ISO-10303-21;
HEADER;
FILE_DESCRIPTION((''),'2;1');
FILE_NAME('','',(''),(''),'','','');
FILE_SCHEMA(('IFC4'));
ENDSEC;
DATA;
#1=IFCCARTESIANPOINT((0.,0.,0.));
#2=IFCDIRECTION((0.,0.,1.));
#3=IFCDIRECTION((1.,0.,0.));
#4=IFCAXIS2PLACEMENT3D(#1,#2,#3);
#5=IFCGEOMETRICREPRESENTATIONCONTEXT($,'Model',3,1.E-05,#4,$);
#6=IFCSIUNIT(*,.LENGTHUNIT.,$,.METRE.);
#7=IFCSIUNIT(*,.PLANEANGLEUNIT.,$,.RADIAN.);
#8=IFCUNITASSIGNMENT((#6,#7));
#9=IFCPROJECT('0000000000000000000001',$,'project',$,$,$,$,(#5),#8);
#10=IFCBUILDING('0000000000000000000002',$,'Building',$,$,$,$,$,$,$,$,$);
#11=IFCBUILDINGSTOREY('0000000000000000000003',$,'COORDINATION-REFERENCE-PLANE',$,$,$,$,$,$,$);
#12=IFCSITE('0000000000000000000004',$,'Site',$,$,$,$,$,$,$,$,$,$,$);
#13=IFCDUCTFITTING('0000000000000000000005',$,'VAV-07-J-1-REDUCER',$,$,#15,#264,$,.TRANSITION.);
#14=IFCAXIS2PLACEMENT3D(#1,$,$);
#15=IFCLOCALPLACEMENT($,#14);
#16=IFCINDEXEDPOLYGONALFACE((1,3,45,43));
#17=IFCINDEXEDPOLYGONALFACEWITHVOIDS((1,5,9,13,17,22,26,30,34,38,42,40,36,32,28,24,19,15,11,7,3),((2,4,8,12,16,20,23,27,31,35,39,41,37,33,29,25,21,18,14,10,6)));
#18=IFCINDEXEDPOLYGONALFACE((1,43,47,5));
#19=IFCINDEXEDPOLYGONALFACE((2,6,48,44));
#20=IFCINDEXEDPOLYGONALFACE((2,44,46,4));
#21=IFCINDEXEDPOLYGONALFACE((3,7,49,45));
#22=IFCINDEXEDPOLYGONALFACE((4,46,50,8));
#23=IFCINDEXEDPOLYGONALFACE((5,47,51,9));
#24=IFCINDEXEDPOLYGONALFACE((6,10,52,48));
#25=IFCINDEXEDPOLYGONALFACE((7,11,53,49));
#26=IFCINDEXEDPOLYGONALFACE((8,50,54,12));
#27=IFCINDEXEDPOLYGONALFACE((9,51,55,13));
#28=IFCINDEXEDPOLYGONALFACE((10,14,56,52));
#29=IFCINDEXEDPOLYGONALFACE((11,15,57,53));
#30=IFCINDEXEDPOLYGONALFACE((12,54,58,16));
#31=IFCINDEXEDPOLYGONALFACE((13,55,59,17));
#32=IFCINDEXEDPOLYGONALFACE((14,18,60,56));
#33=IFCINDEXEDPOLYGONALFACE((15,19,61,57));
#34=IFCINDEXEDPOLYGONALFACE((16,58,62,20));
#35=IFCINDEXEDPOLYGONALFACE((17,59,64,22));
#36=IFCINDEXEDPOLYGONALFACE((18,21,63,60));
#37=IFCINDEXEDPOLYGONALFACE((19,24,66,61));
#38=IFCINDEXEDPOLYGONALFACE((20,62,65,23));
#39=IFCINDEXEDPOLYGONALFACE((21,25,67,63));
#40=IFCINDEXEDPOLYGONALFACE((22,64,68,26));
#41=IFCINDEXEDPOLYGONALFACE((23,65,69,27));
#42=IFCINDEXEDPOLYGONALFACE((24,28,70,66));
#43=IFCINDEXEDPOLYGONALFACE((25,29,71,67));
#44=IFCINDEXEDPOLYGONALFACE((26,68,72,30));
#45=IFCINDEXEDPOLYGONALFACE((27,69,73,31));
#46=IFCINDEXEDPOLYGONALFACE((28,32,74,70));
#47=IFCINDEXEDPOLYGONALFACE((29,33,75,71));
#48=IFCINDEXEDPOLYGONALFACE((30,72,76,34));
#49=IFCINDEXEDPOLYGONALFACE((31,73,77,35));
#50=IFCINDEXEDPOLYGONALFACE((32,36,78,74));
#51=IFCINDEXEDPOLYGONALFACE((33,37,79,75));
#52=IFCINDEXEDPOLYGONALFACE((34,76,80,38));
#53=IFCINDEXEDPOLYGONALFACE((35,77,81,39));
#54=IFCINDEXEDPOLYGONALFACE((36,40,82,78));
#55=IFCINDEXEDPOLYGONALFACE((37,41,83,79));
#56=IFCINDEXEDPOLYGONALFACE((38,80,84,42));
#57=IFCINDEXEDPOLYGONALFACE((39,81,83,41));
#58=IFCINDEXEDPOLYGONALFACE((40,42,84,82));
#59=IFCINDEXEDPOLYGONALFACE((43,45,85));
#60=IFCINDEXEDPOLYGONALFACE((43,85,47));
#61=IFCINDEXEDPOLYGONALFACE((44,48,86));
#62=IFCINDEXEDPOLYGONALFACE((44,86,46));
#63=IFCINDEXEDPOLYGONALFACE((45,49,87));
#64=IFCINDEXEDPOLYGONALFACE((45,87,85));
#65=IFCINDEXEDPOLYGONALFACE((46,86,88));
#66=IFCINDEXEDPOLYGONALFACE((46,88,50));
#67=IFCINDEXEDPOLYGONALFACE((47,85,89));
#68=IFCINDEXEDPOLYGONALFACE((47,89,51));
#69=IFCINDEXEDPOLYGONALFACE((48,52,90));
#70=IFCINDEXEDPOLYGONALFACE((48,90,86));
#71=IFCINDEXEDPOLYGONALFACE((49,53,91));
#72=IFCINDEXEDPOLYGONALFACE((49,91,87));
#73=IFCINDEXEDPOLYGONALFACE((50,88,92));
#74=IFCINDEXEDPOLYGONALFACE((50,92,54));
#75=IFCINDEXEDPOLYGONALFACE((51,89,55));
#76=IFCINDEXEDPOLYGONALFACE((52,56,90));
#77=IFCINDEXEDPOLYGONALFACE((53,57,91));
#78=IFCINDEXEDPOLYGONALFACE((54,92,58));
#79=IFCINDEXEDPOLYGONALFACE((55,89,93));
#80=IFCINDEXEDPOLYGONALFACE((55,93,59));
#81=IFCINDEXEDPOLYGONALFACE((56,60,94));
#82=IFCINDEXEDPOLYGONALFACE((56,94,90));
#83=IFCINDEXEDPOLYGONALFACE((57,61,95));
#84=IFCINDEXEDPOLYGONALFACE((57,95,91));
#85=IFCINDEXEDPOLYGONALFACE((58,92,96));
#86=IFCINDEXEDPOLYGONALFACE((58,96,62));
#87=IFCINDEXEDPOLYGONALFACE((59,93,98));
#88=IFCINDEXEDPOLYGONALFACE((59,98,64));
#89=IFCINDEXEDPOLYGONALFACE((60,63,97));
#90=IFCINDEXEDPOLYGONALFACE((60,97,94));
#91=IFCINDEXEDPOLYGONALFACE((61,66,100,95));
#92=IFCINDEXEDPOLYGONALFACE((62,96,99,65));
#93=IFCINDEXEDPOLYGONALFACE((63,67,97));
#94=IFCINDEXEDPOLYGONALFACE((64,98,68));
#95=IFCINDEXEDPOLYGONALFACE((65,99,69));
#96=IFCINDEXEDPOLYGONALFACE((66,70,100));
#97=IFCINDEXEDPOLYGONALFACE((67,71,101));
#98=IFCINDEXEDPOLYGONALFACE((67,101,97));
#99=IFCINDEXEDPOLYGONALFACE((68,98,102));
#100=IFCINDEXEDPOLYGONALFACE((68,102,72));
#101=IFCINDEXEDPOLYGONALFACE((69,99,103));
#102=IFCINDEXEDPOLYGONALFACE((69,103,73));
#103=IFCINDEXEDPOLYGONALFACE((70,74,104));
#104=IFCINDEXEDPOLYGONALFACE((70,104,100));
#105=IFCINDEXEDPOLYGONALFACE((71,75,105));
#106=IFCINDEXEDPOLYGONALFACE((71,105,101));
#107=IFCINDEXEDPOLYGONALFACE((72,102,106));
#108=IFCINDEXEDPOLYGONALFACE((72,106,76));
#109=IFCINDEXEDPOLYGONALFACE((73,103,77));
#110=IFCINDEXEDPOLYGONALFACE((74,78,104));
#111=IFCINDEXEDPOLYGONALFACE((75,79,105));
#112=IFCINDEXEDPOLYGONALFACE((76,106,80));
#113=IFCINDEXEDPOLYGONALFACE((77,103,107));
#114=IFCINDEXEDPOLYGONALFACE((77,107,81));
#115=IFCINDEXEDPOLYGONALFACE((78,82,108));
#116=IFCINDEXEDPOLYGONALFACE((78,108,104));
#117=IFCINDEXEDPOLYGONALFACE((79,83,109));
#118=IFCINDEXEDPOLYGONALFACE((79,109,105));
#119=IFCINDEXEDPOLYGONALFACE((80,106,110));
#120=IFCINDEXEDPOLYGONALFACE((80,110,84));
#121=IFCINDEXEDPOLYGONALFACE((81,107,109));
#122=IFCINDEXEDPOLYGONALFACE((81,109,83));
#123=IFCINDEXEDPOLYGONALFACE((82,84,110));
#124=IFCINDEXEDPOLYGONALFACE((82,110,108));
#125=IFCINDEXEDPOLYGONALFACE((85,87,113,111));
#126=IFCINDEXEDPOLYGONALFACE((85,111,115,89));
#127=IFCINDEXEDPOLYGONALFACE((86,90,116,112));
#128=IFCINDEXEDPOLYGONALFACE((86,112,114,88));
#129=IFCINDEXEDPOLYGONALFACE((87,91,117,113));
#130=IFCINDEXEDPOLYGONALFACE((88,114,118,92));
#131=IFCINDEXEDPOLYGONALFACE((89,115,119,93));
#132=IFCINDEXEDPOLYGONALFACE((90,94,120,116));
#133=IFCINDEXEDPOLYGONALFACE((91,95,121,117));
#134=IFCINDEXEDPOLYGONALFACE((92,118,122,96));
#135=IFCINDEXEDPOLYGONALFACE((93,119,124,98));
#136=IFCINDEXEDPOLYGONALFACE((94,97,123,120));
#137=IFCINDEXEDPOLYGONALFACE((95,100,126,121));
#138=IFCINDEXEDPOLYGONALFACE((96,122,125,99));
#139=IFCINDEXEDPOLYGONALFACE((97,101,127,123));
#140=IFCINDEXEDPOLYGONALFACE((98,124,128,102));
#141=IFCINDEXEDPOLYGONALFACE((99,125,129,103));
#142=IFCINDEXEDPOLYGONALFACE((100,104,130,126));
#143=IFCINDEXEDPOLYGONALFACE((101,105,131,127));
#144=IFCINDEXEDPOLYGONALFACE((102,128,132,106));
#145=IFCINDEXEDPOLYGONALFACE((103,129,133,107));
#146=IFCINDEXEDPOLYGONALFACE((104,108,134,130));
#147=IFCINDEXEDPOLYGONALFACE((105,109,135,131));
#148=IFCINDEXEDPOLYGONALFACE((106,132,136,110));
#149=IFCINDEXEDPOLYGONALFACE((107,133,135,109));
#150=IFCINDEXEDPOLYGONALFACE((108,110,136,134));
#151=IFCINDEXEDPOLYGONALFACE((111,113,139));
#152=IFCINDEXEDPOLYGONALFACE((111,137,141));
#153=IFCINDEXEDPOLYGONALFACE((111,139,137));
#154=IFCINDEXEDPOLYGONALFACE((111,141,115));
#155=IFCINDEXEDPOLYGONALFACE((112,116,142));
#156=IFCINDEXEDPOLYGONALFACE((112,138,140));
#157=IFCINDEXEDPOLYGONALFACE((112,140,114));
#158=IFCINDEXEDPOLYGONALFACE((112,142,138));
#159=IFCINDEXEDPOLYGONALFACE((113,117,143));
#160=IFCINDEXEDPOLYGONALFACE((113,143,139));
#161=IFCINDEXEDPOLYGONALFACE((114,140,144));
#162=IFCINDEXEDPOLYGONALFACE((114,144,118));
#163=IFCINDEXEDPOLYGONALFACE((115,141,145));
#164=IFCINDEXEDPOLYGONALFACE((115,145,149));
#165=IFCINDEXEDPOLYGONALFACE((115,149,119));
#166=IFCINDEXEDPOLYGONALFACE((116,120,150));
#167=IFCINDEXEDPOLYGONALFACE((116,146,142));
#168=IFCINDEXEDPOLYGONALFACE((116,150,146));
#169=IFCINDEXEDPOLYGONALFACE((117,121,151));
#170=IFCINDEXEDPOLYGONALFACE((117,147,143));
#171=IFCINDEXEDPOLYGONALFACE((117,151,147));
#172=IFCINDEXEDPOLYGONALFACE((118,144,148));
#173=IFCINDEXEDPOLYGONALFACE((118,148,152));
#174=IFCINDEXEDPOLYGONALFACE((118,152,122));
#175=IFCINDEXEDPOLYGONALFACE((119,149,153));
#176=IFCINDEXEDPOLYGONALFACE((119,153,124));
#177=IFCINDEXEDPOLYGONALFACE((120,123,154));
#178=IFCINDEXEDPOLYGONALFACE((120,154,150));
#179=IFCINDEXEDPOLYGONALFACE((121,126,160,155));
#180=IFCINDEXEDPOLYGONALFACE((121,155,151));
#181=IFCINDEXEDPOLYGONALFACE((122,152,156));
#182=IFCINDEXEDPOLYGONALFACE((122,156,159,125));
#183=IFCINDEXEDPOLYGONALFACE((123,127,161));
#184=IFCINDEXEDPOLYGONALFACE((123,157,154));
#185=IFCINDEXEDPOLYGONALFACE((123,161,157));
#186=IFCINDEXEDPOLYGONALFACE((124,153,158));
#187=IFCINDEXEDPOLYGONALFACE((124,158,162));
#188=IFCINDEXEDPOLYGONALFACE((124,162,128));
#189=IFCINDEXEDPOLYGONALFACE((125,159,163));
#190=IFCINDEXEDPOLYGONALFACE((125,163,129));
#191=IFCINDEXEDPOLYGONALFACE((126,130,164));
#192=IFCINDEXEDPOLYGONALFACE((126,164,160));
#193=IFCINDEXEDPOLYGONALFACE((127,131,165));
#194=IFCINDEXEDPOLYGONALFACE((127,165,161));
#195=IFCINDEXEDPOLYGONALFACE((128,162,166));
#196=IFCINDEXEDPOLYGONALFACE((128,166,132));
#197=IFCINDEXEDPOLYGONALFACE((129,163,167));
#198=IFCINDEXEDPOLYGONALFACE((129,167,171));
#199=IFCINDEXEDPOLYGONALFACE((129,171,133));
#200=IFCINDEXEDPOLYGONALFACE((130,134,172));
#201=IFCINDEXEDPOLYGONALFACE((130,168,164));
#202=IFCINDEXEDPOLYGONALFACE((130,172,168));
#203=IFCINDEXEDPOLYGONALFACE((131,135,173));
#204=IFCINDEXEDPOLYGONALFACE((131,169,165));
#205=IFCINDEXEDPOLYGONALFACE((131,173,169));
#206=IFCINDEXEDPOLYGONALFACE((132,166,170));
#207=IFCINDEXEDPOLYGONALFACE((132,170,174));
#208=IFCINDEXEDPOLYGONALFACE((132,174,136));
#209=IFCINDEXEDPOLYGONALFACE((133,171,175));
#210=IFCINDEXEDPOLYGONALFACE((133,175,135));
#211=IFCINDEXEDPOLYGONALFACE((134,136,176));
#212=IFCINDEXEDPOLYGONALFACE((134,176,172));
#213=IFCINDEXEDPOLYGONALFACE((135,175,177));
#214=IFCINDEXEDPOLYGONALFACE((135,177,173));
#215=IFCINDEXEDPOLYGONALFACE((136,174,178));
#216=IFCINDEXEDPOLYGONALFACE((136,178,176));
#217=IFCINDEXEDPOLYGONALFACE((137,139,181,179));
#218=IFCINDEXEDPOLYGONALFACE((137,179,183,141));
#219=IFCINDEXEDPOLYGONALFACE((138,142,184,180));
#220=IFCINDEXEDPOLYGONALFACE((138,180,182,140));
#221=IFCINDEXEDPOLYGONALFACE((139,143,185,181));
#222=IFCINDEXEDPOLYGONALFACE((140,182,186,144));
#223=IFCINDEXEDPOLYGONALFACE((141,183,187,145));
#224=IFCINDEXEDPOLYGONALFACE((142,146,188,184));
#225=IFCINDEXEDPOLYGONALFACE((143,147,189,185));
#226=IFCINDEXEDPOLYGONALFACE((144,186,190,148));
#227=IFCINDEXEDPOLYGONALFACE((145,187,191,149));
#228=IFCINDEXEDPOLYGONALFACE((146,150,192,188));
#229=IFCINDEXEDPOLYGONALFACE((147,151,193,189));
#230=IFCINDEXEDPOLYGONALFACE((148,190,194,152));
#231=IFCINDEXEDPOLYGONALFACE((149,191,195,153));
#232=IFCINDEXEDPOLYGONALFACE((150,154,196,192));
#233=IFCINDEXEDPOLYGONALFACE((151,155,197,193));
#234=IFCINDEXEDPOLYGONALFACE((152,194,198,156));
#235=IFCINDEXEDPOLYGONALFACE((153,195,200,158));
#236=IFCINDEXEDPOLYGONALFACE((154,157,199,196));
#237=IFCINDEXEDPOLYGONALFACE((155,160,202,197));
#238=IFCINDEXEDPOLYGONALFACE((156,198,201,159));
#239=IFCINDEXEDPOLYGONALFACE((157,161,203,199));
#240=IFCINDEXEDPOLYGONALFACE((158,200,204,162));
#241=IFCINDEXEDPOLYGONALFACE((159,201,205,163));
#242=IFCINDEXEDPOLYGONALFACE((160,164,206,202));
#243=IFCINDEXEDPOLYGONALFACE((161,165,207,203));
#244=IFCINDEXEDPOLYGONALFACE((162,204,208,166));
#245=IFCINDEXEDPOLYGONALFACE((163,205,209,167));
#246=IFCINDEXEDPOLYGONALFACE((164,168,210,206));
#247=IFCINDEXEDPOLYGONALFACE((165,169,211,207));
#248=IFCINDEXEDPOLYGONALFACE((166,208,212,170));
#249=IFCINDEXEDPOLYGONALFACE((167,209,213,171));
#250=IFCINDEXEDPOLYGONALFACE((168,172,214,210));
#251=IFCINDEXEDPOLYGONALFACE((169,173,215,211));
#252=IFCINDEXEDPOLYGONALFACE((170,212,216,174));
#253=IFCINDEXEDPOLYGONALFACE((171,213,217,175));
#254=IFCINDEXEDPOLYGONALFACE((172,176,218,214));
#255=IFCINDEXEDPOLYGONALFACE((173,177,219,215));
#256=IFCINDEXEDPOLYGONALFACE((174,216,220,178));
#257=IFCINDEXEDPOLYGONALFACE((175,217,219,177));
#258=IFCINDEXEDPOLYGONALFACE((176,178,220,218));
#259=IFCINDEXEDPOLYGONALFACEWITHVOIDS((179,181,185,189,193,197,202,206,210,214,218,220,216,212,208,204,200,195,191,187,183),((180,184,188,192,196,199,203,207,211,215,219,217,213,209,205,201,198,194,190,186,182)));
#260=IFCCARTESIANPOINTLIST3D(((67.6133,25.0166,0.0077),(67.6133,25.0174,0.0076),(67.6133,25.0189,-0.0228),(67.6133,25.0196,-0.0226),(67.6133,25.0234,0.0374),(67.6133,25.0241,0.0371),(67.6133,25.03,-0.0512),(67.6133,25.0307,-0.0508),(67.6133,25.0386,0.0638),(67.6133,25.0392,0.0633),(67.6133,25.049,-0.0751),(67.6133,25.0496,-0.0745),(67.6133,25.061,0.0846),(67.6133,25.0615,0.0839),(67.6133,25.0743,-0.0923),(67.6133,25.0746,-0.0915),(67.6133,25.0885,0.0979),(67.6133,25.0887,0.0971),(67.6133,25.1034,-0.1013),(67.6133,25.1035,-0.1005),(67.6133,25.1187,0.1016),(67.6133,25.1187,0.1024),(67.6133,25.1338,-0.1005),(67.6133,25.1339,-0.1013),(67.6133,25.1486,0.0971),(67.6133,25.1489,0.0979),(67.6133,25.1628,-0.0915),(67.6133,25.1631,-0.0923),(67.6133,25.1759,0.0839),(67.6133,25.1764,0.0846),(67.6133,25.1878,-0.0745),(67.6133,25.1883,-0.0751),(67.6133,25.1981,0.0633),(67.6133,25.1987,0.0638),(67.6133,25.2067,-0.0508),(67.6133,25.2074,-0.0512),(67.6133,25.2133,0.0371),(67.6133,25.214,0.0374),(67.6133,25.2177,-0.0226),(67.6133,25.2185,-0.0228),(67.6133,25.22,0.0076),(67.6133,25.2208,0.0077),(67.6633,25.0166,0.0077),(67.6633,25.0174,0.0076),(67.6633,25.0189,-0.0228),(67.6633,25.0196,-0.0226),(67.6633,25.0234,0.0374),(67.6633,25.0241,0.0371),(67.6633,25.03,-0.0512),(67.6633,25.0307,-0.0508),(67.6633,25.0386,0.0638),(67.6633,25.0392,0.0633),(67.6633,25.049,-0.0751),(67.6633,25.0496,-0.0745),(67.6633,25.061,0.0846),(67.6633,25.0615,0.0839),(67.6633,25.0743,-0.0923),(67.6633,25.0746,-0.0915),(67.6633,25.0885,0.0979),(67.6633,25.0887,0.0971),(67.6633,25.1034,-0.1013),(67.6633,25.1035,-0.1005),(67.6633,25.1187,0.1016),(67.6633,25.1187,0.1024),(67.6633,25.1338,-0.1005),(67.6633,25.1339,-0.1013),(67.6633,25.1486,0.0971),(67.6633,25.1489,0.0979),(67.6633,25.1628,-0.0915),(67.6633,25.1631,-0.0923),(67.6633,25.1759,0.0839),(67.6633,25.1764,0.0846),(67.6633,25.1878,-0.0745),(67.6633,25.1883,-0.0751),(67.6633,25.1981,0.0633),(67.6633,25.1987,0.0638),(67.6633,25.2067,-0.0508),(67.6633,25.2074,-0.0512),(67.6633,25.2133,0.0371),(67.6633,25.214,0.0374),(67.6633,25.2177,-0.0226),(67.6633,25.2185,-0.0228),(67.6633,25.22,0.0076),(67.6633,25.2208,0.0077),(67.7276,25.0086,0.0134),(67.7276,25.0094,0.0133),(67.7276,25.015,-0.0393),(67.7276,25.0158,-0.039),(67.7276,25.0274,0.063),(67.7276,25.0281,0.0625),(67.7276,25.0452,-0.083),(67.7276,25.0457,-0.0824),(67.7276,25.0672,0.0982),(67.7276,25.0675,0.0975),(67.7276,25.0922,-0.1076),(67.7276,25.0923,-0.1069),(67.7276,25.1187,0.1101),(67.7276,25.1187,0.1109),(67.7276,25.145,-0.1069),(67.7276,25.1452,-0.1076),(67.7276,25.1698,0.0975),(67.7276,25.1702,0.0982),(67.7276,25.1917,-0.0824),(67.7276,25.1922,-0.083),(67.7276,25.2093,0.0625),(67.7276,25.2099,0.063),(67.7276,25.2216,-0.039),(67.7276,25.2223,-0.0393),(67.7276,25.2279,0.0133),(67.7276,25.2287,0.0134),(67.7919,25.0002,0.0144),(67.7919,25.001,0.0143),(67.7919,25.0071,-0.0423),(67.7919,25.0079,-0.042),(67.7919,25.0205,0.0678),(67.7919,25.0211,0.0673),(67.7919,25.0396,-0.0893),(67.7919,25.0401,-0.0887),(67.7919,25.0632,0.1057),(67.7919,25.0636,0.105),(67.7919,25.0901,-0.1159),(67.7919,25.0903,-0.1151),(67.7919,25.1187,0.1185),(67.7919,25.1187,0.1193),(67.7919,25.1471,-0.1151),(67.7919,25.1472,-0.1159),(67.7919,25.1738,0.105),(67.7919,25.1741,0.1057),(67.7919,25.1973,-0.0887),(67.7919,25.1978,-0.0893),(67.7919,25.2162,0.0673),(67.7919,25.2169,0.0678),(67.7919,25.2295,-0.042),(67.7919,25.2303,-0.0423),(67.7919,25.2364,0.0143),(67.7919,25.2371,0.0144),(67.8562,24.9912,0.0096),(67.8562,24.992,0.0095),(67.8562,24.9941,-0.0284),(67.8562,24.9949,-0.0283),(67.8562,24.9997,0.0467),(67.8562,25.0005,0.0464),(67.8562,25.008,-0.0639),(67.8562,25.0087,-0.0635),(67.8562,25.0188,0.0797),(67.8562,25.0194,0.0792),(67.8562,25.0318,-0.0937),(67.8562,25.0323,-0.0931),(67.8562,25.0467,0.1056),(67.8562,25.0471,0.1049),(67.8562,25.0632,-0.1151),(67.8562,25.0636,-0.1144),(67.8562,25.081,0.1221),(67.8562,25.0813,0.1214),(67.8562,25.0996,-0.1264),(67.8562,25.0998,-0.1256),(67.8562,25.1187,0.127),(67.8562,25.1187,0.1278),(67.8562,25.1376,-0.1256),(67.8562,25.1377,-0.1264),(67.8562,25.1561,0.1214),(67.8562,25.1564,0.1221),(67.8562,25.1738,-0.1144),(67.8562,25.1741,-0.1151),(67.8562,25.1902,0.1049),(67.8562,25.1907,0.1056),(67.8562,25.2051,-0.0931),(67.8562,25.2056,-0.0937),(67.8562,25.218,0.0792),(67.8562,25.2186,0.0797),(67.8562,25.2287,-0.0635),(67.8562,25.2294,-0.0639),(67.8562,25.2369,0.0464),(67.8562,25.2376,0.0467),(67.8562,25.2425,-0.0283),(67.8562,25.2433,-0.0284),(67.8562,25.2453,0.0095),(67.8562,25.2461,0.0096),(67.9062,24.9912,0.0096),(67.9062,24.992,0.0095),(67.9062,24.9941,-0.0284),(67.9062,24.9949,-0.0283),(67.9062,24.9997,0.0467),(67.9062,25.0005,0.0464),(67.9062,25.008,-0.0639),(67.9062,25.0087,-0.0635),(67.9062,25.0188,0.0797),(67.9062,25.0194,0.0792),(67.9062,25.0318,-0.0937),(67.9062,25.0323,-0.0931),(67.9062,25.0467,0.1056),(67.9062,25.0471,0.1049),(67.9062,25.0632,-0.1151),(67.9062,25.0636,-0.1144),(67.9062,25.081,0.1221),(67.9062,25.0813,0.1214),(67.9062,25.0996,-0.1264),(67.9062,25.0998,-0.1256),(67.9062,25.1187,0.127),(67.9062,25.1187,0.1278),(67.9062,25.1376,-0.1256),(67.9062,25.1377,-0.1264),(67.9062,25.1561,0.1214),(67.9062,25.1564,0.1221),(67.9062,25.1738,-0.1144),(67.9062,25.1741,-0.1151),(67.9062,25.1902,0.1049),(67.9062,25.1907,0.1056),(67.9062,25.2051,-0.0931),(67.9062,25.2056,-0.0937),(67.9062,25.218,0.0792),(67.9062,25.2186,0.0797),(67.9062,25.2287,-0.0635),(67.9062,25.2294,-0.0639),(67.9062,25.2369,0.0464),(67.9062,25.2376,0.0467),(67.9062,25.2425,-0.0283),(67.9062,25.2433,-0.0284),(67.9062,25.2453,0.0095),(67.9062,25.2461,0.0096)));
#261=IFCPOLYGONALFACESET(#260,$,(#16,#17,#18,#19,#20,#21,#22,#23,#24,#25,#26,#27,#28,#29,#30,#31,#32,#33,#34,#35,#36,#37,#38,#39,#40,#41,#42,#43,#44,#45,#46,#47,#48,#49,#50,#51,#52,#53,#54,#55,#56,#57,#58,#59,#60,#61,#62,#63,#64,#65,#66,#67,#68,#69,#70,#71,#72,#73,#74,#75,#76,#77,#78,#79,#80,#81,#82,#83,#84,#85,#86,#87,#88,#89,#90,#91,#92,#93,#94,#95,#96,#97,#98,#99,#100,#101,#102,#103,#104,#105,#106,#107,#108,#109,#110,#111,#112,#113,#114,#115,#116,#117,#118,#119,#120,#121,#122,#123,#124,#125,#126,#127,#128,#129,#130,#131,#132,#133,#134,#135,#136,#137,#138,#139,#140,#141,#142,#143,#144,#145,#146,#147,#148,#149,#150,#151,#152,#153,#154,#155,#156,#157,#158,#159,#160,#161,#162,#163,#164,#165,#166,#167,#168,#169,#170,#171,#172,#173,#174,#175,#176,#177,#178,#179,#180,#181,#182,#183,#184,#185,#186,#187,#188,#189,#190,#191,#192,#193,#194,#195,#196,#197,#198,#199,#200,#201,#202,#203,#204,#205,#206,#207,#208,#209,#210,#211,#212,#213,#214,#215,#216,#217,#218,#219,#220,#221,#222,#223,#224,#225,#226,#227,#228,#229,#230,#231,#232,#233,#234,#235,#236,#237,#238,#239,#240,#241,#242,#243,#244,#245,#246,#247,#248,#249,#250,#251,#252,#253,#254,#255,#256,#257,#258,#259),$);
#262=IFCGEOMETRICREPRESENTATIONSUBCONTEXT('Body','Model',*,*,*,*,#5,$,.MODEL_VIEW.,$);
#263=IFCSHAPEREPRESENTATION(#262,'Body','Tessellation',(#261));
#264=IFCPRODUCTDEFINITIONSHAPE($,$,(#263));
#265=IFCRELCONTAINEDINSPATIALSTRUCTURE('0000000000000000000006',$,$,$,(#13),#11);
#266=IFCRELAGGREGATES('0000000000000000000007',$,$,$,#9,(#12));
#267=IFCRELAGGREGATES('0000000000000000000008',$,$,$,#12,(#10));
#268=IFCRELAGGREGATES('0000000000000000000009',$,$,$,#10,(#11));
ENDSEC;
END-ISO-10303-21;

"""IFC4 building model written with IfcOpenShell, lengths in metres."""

from ifc_helpers import new_model, entity, si_unit, frame, origin_with_axes, place, context, subcontext, project, spatial, element, save


model = new_model("IFC4")

# Units and contexts
model_context = context("Model", 3, precision=1e-05, world=origin_with_axes())
body_context_1 = subcontext(model_context, "Body", "Model", "MODEL_VIEW")
ifc_project = project(units=[si_unit("LENGTHUNIT", "METRE"), si_unit("PLANEANGLEUNIT", "RADIAN")], contexts=[model_context])

# Site, building, storey
site = spatial("IfcSite", under=ifc_project, Name="Site")
building = spatial("IfcBuilding", under=site, Name="Building")
storey = spatial("IfcBuildingStorey", under=building, Name="COORDINATION-REFERENCE-PLANE")

# Duct fitting
for number, where, z_axis, x_axis, name in (
    (1, (67.9062, 25.1187, 0.0), (0.0, -1.0, 0.0), (0.0, 0.0, 1.0), "VAV-07-J-1-REDUCER"),
):
    element("IfcDuctFitting", number, at=place(None, frame(where, z_axis=z_axis, x_axis=x_axis)), inside=storey, Name=name, PredefinedType="TRANSITION", context=body_context_1, shape_type="SweptSolid", body=[
        entity("IfcRevolvedAreaSolid", entity("IfcArbitraryClosedProfileDef", "AREA", None, entity("IfcPolyline", [entity("IfcCartesianPoint", [0.1278, 0.0]), entity("IfcCartesianPoint", [0.1278, 0.05]), entity("IfcCartesianPoint", [0.1024, 0.2429]), entity("IfcCartesianPoint", [0.1024, 0.2929]), entity("IfcCartesianPoint", [0.1016, 0.2929]), entity("IfcCartesianPoint", [0.1016, 0.2429]), entity("IfcCartesianPoint", [0.127, 0.05]), entity("IfcCartesianPoint", [0.127, 0.0]), entity("IfcCartesianPoint", [0.1278, 0.0])])), entity("IfcAxis2Placement3D", entity("IfcCartesianPoint", [0.0, 0.0, 0.0])), entity("IfcAxis1Placement", entity("IfcCartesianPoint", [0.0, 0.0, 0.0]), entity("IfcDirection", [0.0, 1.0, 0.0])), 6.283185),
    ])

save(model, "model.ifc")
